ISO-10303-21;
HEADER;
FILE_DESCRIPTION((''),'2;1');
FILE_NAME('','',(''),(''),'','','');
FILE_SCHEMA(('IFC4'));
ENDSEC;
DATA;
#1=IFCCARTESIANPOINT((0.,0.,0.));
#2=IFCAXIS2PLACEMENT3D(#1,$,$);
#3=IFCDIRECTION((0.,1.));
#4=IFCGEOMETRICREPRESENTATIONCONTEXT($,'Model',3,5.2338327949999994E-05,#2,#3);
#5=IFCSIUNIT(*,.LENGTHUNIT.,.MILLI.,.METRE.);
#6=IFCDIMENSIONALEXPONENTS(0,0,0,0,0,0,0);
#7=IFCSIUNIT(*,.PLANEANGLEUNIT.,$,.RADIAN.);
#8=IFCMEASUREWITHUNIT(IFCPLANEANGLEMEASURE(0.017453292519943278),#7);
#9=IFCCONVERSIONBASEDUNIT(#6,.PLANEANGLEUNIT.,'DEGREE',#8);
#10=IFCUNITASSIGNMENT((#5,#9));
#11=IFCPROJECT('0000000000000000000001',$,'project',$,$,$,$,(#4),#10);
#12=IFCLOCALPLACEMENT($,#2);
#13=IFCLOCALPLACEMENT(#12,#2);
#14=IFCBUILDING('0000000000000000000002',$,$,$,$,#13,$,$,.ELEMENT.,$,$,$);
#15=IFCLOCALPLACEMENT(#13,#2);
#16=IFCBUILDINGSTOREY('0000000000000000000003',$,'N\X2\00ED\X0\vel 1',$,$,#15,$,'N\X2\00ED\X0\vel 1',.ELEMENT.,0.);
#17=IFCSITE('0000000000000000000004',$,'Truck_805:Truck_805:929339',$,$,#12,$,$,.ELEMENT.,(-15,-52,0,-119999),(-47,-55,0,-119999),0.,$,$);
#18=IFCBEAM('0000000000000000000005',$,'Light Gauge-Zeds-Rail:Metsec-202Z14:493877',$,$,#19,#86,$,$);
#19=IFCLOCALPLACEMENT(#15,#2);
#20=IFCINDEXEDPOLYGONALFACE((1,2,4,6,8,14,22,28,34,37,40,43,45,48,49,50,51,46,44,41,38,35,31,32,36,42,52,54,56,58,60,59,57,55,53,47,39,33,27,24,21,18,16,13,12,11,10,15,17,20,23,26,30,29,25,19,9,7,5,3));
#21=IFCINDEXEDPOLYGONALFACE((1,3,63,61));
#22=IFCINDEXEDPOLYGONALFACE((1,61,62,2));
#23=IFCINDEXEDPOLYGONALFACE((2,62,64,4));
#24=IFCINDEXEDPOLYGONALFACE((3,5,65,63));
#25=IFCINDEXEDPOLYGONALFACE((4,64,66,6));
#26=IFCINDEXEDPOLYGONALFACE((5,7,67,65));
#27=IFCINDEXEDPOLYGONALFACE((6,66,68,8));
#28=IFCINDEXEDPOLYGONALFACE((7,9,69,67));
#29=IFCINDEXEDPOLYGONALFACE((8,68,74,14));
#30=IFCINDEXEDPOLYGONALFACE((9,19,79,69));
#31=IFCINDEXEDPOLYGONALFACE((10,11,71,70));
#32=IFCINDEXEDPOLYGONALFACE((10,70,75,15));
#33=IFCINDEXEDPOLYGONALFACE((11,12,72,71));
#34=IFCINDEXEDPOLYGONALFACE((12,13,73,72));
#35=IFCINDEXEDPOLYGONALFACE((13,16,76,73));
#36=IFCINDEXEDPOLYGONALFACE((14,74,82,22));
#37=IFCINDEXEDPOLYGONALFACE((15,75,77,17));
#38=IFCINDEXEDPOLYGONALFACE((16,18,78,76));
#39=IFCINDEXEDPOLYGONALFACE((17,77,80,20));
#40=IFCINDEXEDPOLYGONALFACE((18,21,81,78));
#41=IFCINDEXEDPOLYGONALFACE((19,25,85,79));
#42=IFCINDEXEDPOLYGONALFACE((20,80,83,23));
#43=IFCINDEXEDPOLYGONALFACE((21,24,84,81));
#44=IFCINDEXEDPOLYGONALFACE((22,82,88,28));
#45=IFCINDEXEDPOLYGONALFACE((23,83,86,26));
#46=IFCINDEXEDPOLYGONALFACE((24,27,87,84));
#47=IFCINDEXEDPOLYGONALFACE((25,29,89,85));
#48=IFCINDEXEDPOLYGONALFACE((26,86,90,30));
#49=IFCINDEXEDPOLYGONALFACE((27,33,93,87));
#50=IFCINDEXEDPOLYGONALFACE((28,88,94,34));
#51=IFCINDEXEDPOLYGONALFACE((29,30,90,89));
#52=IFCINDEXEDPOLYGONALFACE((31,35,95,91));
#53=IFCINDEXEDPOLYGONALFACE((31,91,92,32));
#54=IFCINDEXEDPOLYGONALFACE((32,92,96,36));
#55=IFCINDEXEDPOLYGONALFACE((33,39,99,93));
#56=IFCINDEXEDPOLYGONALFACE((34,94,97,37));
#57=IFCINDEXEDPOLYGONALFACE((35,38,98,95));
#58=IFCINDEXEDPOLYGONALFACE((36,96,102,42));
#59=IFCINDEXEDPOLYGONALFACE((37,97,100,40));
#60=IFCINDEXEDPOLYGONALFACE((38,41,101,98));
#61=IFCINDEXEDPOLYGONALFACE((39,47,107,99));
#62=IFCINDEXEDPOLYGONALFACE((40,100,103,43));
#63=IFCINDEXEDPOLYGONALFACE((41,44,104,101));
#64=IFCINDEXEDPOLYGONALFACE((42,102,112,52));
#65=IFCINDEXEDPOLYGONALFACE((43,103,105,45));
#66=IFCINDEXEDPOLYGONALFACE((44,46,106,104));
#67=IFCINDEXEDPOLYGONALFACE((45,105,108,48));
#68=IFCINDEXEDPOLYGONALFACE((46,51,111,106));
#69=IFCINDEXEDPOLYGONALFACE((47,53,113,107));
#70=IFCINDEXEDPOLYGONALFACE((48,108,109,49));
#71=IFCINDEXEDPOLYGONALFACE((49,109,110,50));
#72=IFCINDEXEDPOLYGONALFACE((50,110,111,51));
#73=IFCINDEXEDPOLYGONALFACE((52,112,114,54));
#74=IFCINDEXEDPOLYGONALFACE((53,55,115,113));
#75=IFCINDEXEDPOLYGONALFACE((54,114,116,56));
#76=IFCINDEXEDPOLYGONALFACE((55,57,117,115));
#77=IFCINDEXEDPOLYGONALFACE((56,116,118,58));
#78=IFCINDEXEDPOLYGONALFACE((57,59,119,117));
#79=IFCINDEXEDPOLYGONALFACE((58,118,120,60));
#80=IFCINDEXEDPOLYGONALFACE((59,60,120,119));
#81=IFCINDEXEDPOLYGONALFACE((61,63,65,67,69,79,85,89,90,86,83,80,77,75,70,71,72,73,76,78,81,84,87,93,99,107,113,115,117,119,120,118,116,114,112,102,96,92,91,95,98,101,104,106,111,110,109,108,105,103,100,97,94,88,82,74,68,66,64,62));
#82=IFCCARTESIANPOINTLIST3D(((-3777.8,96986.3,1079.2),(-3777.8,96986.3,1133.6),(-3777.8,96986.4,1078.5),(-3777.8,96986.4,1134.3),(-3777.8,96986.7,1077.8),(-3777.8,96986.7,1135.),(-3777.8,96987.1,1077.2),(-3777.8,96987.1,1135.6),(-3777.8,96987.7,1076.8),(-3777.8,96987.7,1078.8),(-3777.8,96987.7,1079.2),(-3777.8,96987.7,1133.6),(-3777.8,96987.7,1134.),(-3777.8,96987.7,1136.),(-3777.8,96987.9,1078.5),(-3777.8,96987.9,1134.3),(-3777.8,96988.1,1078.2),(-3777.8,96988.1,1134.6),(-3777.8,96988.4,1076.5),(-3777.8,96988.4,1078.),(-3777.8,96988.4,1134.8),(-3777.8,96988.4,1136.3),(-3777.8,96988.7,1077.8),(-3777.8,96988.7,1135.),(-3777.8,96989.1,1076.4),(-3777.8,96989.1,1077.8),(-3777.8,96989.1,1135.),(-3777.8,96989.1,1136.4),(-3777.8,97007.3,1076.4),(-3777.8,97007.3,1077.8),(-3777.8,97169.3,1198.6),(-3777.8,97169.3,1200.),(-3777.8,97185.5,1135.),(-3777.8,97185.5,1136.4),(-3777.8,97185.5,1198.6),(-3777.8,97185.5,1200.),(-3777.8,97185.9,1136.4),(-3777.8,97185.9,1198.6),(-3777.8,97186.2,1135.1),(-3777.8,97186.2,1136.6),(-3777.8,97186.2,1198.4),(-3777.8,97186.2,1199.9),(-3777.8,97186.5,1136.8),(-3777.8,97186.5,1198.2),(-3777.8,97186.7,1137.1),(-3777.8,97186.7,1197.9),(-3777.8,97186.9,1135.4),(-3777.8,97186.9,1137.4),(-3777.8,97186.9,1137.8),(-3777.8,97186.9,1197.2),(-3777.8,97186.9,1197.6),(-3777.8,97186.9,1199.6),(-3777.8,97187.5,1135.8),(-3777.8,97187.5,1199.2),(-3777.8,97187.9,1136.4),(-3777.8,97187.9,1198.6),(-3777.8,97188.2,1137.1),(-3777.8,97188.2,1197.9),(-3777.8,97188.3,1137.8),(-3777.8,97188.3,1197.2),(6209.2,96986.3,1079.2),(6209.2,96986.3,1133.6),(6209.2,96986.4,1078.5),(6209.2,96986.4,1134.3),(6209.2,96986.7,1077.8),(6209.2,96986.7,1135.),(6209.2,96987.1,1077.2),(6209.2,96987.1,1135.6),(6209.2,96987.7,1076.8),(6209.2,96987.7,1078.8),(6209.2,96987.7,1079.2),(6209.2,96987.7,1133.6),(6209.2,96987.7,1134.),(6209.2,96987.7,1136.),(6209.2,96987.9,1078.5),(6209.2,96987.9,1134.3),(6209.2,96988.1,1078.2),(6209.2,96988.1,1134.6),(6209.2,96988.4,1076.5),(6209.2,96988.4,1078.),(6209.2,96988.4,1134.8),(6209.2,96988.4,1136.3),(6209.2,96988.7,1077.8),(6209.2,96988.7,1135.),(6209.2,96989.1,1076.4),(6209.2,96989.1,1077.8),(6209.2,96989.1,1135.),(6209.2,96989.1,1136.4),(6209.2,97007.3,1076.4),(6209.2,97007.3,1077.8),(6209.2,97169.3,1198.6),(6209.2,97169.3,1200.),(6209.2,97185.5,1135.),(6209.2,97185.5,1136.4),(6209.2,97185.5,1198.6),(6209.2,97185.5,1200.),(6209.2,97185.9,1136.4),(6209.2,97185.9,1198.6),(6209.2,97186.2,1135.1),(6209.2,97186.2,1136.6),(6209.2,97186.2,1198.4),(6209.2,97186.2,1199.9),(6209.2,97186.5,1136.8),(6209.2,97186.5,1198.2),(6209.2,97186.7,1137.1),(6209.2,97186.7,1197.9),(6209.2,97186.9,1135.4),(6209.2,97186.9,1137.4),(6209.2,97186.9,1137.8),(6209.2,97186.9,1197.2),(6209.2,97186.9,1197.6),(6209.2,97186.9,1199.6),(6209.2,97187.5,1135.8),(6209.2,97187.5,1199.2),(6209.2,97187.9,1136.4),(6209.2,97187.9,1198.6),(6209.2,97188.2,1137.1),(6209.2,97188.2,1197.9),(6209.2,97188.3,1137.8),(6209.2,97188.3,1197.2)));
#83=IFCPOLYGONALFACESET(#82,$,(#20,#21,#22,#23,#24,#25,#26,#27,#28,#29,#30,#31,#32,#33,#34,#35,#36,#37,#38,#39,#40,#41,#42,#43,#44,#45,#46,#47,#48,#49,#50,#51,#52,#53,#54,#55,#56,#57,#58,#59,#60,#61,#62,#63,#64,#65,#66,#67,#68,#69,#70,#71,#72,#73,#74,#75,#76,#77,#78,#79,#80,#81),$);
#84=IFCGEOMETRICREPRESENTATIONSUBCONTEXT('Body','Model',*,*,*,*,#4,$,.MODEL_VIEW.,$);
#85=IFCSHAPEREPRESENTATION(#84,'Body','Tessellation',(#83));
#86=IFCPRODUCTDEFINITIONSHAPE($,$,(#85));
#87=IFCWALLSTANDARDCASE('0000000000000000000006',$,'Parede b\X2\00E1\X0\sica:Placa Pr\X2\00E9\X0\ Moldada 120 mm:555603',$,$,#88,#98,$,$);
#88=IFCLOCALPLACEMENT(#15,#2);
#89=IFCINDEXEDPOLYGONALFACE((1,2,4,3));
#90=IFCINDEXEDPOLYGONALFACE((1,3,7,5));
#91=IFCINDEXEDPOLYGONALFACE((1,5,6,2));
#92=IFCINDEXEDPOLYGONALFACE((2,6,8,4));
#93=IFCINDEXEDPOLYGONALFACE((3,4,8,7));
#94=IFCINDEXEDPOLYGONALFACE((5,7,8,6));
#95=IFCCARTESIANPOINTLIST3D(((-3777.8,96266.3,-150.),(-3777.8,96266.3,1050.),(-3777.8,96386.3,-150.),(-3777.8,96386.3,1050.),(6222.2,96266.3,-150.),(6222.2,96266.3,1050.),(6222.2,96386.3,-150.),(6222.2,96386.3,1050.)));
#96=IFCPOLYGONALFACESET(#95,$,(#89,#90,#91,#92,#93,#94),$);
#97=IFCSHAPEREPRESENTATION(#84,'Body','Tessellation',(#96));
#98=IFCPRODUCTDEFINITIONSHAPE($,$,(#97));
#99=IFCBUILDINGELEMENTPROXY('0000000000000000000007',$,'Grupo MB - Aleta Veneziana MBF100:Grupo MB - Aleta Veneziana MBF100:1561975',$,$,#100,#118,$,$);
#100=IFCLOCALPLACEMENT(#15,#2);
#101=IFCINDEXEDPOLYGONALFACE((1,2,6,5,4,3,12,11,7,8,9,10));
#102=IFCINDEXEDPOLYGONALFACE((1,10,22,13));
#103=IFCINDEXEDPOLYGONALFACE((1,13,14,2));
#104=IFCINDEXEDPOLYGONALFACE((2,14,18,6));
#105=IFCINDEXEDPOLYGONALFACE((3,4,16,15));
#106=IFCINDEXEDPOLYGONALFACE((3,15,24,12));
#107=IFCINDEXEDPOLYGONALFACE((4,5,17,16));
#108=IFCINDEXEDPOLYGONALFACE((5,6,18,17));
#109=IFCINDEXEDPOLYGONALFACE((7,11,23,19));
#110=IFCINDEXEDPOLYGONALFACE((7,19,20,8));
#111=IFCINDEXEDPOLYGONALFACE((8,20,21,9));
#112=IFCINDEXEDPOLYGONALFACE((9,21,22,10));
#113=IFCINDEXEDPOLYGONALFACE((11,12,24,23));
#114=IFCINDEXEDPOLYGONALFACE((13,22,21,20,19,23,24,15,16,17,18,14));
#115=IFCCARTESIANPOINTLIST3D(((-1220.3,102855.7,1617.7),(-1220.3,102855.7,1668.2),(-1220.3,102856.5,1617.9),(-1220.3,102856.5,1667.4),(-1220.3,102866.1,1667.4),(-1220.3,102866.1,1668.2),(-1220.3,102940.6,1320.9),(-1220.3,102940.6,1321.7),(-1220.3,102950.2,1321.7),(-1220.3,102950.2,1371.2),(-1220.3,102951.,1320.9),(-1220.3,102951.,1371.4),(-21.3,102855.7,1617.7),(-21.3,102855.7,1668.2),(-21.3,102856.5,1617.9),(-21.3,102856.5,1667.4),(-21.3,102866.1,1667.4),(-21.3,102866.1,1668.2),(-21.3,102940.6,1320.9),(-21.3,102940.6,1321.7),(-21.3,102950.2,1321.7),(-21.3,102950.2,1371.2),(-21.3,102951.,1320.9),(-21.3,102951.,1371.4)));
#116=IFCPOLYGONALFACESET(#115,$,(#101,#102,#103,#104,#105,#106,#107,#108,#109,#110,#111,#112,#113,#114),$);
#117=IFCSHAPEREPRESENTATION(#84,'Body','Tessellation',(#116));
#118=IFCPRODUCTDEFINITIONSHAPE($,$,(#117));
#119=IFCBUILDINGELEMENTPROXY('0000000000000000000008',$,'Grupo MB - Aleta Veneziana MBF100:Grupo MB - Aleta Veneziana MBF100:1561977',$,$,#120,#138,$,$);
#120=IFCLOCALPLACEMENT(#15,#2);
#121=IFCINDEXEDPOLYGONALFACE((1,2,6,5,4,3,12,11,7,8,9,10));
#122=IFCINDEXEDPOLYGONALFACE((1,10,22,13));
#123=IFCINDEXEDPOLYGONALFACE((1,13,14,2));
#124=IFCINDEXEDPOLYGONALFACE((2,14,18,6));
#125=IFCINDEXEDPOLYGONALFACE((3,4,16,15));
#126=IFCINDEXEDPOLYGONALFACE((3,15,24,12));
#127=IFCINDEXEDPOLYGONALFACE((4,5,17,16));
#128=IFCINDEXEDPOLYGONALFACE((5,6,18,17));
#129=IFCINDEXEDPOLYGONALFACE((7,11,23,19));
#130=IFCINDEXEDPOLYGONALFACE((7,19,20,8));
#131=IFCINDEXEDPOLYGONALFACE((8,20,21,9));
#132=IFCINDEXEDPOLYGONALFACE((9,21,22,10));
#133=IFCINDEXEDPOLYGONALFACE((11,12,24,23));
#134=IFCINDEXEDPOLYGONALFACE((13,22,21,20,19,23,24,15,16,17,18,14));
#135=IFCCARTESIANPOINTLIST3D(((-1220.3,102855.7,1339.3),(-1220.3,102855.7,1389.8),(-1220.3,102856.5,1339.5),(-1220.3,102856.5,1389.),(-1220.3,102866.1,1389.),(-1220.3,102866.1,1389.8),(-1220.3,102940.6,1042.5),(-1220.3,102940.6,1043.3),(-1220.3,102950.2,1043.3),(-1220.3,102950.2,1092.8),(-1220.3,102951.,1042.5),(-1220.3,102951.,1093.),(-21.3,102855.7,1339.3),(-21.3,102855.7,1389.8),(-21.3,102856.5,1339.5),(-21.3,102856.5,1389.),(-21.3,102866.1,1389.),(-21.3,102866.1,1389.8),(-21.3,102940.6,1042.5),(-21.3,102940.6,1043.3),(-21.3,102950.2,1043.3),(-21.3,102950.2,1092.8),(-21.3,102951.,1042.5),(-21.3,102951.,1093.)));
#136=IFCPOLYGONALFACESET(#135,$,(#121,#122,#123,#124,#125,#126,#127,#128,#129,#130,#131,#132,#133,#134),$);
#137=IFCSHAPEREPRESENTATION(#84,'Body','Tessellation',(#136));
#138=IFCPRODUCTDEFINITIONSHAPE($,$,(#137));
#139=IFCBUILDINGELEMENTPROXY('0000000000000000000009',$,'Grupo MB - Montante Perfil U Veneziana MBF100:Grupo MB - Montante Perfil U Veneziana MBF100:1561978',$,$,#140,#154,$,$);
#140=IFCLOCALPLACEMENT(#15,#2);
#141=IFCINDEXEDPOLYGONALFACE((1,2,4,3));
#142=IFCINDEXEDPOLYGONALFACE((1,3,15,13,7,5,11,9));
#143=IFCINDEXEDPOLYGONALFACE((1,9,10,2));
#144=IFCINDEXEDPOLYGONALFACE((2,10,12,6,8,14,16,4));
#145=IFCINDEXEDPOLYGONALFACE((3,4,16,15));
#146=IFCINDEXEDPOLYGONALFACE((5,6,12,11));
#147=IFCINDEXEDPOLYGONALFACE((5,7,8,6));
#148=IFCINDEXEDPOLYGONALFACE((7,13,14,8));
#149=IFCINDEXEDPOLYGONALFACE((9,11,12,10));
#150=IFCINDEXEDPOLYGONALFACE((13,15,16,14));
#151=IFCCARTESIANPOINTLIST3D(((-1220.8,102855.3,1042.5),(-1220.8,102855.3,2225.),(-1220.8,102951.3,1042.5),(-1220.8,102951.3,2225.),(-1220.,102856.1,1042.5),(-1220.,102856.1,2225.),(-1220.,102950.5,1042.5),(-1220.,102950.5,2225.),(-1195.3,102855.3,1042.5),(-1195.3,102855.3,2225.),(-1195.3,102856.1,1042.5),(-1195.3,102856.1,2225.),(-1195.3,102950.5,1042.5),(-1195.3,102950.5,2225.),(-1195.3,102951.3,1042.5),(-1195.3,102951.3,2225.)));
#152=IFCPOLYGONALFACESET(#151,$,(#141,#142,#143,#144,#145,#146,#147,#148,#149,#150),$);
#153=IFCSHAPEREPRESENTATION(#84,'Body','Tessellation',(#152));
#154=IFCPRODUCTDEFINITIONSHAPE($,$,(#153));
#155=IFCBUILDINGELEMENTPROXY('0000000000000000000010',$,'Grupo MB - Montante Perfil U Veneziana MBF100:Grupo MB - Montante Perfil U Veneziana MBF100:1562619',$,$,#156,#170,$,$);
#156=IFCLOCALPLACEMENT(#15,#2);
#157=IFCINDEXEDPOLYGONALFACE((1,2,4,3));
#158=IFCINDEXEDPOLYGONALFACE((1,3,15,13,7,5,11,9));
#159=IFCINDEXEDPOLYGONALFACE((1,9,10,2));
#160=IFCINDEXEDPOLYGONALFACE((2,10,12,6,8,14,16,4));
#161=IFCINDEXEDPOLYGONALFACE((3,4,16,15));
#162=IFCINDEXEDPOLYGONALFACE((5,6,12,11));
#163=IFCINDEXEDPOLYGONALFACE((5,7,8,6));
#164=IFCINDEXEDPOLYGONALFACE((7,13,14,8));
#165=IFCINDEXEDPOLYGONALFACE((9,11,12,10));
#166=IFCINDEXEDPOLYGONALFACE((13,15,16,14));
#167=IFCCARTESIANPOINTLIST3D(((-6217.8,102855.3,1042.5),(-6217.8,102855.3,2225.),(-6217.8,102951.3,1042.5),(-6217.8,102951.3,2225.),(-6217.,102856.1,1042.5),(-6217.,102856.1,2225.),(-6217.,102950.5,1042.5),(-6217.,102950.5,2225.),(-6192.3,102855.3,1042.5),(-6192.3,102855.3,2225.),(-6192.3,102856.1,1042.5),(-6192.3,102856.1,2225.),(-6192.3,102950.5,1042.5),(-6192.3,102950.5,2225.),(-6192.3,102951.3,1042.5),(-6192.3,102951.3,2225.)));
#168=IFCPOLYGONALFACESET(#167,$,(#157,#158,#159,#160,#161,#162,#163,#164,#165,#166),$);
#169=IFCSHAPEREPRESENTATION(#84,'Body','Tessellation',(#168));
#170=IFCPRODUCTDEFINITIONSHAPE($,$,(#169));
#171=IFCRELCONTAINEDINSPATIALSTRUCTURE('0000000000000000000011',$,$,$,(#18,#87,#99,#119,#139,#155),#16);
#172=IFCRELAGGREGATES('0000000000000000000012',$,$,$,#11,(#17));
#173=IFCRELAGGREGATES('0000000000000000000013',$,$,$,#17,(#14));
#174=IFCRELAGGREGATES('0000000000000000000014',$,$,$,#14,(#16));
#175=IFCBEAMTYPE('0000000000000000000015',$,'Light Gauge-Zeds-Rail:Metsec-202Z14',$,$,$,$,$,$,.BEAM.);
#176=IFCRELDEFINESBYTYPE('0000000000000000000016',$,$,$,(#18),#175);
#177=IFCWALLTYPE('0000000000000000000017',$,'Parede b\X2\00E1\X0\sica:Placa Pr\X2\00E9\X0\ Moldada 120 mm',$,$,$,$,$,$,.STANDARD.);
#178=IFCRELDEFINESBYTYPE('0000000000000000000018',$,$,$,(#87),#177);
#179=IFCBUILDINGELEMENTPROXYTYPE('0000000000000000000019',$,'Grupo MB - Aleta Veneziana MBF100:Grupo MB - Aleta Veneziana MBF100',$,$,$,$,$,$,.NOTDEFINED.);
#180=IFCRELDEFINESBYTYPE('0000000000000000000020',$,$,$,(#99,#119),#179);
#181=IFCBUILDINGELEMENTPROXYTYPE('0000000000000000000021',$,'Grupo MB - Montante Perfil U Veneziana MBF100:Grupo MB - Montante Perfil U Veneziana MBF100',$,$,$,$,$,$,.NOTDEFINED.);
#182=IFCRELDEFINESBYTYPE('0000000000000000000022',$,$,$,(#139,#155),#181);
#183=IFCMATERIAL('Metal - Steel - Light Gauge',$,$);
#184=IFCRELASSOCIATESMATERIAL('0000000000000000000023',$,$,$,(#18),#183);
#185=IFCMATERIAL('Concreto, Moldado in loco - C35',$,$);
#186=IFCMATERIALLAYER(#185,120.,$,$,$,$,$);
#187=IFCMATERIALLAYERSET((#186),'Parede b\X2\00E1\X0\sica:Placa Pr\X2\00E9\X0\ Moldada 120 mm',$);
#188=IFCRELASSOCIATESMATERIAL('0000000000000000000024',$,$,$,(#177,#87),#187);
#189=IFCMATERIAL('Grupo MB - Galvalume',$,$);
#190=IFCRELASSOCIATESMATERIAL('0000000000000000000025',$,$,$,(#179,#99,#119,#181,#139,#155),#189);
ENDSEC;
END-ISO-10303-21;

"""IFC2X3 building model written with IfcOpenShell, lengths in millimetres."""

from ifc_helpers import new_model, entity, si_unit, converted_unit, direction, frame, frame_2d, origin, place, context, subcontext, project, spatial, polyline, circle_curve, parameter, trimmed, segment, composite_curve, rectangle, outline, extrude, source, transform, mapped, material, layer, layer_set, layer_usage, type_object, type_shapes, element, save


model = new_model("IFC2X3")

# Units and contexts
model_context = context("Model", 3, precision=5.2338327949999994e-05, world=origin(), true_north=direction((0.0, 1.0)))
body_context = subcontext(model_context, "Body", "Model", "MODEL_VIEW")
ifc_project = project(units=[si_unit("LENGTHUNIT", "METRE", prefix="MILLI"), converted_unit("PLANEANGLEUNIT", "DEGREE", entity("IfcPlaneAngleMeasure", 0.017453292519943278), si_unit("PLANEANGLEUNIT", "RADIAN"), dimensions=[0, 0, 0, 0, 0, 0, 0])], contexts=[model_context])

# Site, building, storey
site_placement = place(None, origin())
site = spatial("IfcSite", under=ifc_project, at=site_placement, Name="Truck_805:Truck_805:929339", CompositionType="ELEMENT", RefLatitude=(-15, -52, 0, -119999), RefLongitude=(-47, -55, 0, -119999), RefElevation=0.0)
building_placement = place(site_placement, origin())
building = spatial("IfcBuilding", under=site, at=building_placement, CompositionType="ELEMENT")
storey_placement = place(building_placement, origin())
storey = spatial("IfcBuildingStorey", under=building, at=storey_placement, Name="Nível 1", LongName="Nível 1", CompositionType="ELEMENT", Elevation=0.0)

# Beam
ifc_material_1 = material(Name="Metal - Steel - Light Gauge")
beam_type = type_object("IfcBeamType", Name="Light Gauge-Zeds-Rail:Metsec-202Z14", PredefinedType="BEAM")
beam_placement = place(storey_placement, frame((-3777.8, 97088.2, 1200.0)))
element("IfcBeam", 1, at=beam_placement, inside=storey, type_object=beam_type, material=ifc_material_1, Name="Light Gauge-Zeds-Rail:Metsec-202Z14:493877", context=body_context, shape_type="SweptSolid", body=[
    extrude(outline(composite_curve([segment(polyline([(3.6, -101.2), (58.0, -101.2)]), True, "CONTINUOUS"), segment(trimmed(circle_curve(frame_2d((58.0, -98.4), x_axis=(0.0, -1.0)), 2.8), [parameter(0.0)], [parameter(90.0)], True, "PARAMETER"), True, "CONTINUOUS"), segment(polyline([(60.8, -98.4), (60.8, -80.2)]), True, "CONTINUOUS"), segment(polyline([(60.8, -80.2), (59.4, -80.2)]), True, "CONTINUOUS"), segment(polyline([(59.4, -80.2), (59.4, -98.4)]), True, "CONTINUOUS"), segment(trimmed(circle_curve(frame_2d((58.0, -98.4), x_axis=(1.0, 0.0)), 1.4), [parameter(270.0)], [parameter(0.0)], True, "PARAMETER"), False, "CONTINUOUS"), segment(polyline([(58.0, -99.8), (3.6, -99.8)]), True, "CONTINUOUS"), segment(trimmed(circle_curve(frame_2d((3.6, -98.4), x_axis=(0.0, -1.0)), 1.4), [parameter(270.0)], [parameter(0.0)], True, "PARAMETER"), False, "CONTINUOUS"), segment(polyline([(2.2, -98.4), (2.2, 98.0)]), True, "CONTINUOUS"), segment(trimmed(circle_curve(frame_2d((-0.6, 98.0), x_axis=(1.0, 0.0)), 2.8), [parameter(0.0)], [parameter(90.0)], True, "PARAMETER"), True, "CONTINUOUS"), segment(polyline([(-0.6, 100.8), (-60.0, 100.8)]), True, "CONTINUOUS"), segment(trimmed(circle_curve(frame_2d((-60.0, 98.0), x_axis=(0.0, 1.0)), 2.8), [parameter(0.0)], [parameter(90.0)], True, "PARAMETER"), True, "CONTINUOUS"), segment(polyline([(-62.8, 98.0), (-62.8, 81.8)]), True, "CONTINUOUS"), segment(polyline([(-62.8, 81.8), (-61.4, 81.8)]), True, "CONTINUOUS"), segment(polyline([(-61.4, 81.8), (-61.4, 98.0)]), True, "CONTINUOUS"), segment(trimmed(circle_curve(frame_2d((-60.0, 98.0), x_axis=(-1.0, 0.0)), 1.4), [parameter(270.0)], [parameter(0.0)], True, "PARAMETER"), False, "CONTINUOUS"), segment(polyline([(-60.0, 99.4), (-0.6, 99.4)]), True, "CONTINUOUS"), segment(trimmed(circle_curve(frame_2d((-0.6, 98.0), x_axis=(0.0, 1.0)), 1.4), [parameter(270.0)], [parameter(0.0)], True, "PARAMETER"), False, "CONTINUOUS"), segment(polyline([(0.8, 98.0), (0.8, -98.4)]), True, "CONTINUOUS"), segment(trimmed(circle_curve(frame_2d((3.6, -98.4), x_axis=(-1.0, 0.0)), 2.8), [parameter(0.0)], [parameter(90.0)], True, "PARAMETER"), True, "CONTINUOUS")], self_intersect=False)), frame((0.0, -0.7, -62.8), z_axis=(1.0, 0.0, 0.0), x_axis=(0.0, 0.0, -1.0)), (0.0, 0.0, 1.0), 9987.0),
])

# Wall
ifc_material_2 = material(Name="Concreto, Moldado in loco - C35")
ifc_layer = layer(ifc_material_2, 120.0)
ifc_layer_set = layer_set([ifc_layer], Name="Parede básica:Placa Pré Moldada 120 mm")
ifc_layer_usage = layer_usage(ifc_layer_set, "AXIS2", "NEGATIVE", 60.0)
wall_type = type_object("IfcWallType", Name="Parede básica:Placa Pré Moldada 120 mm", PredefinedType="STANDARD", material=ifc_layer_set)
wall_placement = place(storey_placement, frame((-3777.8, 96326.3, -150.0)))
element("IfcWallStandardCase", 2, at=wall_placement, inside=storey, type_object=wall_type, material=ifc_layer_usage, Name="Parede básica:Placa Pré Moldada 120 mm:555603", context=body_context, shape_type="SweptSolid", body=[
    extrude(rectangle(XDim=10000.0, YDim=120.0, at=frame_2d((5000.0, 0.0), x_axis=(-1.0, 0.0))), origin(), (0.0, 0.0, 1.0), 1200.0),
])

# Building element proxies
ifc_material_3 = material(Name="Grupo MB - Galvalume")
building_element_proxy_type_1 = type_object("IfcBuildingElementProxyType", Name="Grupo MB - Aleta Veneziana MBF100:Grupo MB - Aleta Veneziana MBF100", PredefinedType="NOTDEFINED", material=ifc_material_3)
shared_shape_1 = source(origin(), body_context, "Body", "SweptSolid", [
    extrude(outline(polyline([(123.3, -46.8), (-123.2, 47.6), (-173.7, 47.6), (-173.7, 37.2), (-172.9, 37.2), (-172.9, 46.8), (-123.3, 46.8), (123.2, -47.6), (173.7, -47.6), (173.7, -37.2), (172.9, -37.2), (172.9, -46.8), (123.3, -46.8)])), frame((0.0, 47.6, 173.7), z_axis=(-1.0, 0.0, 0.0), x_axis=(0.0, 0.0, -1.0)), (0.0, 0.0, -1.0), 1199.0),
])
type_shapes(building_element_proxy_type_1, [shared_shape_1])
for number, where, name in (
    (3, (-1220.3, 102855.7, 1320.9), "Grupo MB - Aleta Veneziana MBF100:Grupo MB - Aleta Veneziana MBF100:1561975"),
    (4, (-1220.3, 102855.7, 1042.5), "Grupo MB - Aleta Veneziana MBF100:Grupo MB - Aleta Veneziana MBF100:1561977"),
):
    element("IfcBuildingElementProxy", number, at=place(storey_placement, frame(where)), inside=storey, type_object=building_element_proxy_type_1, material=ifc_material_3, Name=name, context=body_context, shape_type="MappedRepresentation", body=[
        mapped(shared_shape_1, transform((0.0, 0.0, 0.0), scale=1.0)),
    ])
building_element_proxy_type_2 = type_object("IfcBuildingElementProxyType", Name="Grupo MB - Montante Perfil U Veneziana MBF100:Grupo MB - Montante Perfil U Veneziana MBF100", PredefinedType="NOTDEFINED", material=ifc_material_3)
shared_shape_2 = source(origin(), body_context, "Body", "SweptSolid", [
    extrude(outline(polyline([(-13.0, -48.0), (12.6, -48.0), (12.6, -47.2), (-12.2, -47.2), (-12.2, 47.2), (12.6, 47.2), (12.6, 48.0), (-13.0, 48.0), (-13.0, -48.0)])), frame((0.0, 48.0, 13.0), z_axis=(1.0, 0.0, 0.0), x_axis=(0.0, 0.0, 1.0)), (0.0, 0.0, 1.0), 1182.5),
])
type_shapes(building_element_proxy_type_2, [shared_shape_2])
for number, where, z_axis, x_axis, name in (
    (5, (-1220.8, 102951.3, 1042.5), (1.0, 0.0, 0.0), (0.0, 0.0, 1.0), "Grupo MB - Montante Perfil U Veneziana MBF100:Grupo MB - Montante Perfil U Veneziana MBF100:1561978"),
    (6, (-6217.8, 102951.3, 1042.5), (1.0, 0.0, 0.0), (0.0, 0.0, 1.0), "Grupo MB - Montante Perfil U Veneziana MBF100:Grupo MB - Montante Perfil U Veneziana MBF100:1562619"),
):
    element("IfcBuildingElementProxy", number, at=place(storey_placement, frame(where, z_axis=z_axis, x_axis=x_axis)), inside=storey, type_object=building_element_proxy_type_2, material=ifc_material_3, Name=name, context=body_context, shape_type="MappedRepresentation", body=[
        mapped(shared_shape_2, transform((0.0, 0.0, 0.0), scale=1.0)),
    ])

save(model, "model.ifc")
